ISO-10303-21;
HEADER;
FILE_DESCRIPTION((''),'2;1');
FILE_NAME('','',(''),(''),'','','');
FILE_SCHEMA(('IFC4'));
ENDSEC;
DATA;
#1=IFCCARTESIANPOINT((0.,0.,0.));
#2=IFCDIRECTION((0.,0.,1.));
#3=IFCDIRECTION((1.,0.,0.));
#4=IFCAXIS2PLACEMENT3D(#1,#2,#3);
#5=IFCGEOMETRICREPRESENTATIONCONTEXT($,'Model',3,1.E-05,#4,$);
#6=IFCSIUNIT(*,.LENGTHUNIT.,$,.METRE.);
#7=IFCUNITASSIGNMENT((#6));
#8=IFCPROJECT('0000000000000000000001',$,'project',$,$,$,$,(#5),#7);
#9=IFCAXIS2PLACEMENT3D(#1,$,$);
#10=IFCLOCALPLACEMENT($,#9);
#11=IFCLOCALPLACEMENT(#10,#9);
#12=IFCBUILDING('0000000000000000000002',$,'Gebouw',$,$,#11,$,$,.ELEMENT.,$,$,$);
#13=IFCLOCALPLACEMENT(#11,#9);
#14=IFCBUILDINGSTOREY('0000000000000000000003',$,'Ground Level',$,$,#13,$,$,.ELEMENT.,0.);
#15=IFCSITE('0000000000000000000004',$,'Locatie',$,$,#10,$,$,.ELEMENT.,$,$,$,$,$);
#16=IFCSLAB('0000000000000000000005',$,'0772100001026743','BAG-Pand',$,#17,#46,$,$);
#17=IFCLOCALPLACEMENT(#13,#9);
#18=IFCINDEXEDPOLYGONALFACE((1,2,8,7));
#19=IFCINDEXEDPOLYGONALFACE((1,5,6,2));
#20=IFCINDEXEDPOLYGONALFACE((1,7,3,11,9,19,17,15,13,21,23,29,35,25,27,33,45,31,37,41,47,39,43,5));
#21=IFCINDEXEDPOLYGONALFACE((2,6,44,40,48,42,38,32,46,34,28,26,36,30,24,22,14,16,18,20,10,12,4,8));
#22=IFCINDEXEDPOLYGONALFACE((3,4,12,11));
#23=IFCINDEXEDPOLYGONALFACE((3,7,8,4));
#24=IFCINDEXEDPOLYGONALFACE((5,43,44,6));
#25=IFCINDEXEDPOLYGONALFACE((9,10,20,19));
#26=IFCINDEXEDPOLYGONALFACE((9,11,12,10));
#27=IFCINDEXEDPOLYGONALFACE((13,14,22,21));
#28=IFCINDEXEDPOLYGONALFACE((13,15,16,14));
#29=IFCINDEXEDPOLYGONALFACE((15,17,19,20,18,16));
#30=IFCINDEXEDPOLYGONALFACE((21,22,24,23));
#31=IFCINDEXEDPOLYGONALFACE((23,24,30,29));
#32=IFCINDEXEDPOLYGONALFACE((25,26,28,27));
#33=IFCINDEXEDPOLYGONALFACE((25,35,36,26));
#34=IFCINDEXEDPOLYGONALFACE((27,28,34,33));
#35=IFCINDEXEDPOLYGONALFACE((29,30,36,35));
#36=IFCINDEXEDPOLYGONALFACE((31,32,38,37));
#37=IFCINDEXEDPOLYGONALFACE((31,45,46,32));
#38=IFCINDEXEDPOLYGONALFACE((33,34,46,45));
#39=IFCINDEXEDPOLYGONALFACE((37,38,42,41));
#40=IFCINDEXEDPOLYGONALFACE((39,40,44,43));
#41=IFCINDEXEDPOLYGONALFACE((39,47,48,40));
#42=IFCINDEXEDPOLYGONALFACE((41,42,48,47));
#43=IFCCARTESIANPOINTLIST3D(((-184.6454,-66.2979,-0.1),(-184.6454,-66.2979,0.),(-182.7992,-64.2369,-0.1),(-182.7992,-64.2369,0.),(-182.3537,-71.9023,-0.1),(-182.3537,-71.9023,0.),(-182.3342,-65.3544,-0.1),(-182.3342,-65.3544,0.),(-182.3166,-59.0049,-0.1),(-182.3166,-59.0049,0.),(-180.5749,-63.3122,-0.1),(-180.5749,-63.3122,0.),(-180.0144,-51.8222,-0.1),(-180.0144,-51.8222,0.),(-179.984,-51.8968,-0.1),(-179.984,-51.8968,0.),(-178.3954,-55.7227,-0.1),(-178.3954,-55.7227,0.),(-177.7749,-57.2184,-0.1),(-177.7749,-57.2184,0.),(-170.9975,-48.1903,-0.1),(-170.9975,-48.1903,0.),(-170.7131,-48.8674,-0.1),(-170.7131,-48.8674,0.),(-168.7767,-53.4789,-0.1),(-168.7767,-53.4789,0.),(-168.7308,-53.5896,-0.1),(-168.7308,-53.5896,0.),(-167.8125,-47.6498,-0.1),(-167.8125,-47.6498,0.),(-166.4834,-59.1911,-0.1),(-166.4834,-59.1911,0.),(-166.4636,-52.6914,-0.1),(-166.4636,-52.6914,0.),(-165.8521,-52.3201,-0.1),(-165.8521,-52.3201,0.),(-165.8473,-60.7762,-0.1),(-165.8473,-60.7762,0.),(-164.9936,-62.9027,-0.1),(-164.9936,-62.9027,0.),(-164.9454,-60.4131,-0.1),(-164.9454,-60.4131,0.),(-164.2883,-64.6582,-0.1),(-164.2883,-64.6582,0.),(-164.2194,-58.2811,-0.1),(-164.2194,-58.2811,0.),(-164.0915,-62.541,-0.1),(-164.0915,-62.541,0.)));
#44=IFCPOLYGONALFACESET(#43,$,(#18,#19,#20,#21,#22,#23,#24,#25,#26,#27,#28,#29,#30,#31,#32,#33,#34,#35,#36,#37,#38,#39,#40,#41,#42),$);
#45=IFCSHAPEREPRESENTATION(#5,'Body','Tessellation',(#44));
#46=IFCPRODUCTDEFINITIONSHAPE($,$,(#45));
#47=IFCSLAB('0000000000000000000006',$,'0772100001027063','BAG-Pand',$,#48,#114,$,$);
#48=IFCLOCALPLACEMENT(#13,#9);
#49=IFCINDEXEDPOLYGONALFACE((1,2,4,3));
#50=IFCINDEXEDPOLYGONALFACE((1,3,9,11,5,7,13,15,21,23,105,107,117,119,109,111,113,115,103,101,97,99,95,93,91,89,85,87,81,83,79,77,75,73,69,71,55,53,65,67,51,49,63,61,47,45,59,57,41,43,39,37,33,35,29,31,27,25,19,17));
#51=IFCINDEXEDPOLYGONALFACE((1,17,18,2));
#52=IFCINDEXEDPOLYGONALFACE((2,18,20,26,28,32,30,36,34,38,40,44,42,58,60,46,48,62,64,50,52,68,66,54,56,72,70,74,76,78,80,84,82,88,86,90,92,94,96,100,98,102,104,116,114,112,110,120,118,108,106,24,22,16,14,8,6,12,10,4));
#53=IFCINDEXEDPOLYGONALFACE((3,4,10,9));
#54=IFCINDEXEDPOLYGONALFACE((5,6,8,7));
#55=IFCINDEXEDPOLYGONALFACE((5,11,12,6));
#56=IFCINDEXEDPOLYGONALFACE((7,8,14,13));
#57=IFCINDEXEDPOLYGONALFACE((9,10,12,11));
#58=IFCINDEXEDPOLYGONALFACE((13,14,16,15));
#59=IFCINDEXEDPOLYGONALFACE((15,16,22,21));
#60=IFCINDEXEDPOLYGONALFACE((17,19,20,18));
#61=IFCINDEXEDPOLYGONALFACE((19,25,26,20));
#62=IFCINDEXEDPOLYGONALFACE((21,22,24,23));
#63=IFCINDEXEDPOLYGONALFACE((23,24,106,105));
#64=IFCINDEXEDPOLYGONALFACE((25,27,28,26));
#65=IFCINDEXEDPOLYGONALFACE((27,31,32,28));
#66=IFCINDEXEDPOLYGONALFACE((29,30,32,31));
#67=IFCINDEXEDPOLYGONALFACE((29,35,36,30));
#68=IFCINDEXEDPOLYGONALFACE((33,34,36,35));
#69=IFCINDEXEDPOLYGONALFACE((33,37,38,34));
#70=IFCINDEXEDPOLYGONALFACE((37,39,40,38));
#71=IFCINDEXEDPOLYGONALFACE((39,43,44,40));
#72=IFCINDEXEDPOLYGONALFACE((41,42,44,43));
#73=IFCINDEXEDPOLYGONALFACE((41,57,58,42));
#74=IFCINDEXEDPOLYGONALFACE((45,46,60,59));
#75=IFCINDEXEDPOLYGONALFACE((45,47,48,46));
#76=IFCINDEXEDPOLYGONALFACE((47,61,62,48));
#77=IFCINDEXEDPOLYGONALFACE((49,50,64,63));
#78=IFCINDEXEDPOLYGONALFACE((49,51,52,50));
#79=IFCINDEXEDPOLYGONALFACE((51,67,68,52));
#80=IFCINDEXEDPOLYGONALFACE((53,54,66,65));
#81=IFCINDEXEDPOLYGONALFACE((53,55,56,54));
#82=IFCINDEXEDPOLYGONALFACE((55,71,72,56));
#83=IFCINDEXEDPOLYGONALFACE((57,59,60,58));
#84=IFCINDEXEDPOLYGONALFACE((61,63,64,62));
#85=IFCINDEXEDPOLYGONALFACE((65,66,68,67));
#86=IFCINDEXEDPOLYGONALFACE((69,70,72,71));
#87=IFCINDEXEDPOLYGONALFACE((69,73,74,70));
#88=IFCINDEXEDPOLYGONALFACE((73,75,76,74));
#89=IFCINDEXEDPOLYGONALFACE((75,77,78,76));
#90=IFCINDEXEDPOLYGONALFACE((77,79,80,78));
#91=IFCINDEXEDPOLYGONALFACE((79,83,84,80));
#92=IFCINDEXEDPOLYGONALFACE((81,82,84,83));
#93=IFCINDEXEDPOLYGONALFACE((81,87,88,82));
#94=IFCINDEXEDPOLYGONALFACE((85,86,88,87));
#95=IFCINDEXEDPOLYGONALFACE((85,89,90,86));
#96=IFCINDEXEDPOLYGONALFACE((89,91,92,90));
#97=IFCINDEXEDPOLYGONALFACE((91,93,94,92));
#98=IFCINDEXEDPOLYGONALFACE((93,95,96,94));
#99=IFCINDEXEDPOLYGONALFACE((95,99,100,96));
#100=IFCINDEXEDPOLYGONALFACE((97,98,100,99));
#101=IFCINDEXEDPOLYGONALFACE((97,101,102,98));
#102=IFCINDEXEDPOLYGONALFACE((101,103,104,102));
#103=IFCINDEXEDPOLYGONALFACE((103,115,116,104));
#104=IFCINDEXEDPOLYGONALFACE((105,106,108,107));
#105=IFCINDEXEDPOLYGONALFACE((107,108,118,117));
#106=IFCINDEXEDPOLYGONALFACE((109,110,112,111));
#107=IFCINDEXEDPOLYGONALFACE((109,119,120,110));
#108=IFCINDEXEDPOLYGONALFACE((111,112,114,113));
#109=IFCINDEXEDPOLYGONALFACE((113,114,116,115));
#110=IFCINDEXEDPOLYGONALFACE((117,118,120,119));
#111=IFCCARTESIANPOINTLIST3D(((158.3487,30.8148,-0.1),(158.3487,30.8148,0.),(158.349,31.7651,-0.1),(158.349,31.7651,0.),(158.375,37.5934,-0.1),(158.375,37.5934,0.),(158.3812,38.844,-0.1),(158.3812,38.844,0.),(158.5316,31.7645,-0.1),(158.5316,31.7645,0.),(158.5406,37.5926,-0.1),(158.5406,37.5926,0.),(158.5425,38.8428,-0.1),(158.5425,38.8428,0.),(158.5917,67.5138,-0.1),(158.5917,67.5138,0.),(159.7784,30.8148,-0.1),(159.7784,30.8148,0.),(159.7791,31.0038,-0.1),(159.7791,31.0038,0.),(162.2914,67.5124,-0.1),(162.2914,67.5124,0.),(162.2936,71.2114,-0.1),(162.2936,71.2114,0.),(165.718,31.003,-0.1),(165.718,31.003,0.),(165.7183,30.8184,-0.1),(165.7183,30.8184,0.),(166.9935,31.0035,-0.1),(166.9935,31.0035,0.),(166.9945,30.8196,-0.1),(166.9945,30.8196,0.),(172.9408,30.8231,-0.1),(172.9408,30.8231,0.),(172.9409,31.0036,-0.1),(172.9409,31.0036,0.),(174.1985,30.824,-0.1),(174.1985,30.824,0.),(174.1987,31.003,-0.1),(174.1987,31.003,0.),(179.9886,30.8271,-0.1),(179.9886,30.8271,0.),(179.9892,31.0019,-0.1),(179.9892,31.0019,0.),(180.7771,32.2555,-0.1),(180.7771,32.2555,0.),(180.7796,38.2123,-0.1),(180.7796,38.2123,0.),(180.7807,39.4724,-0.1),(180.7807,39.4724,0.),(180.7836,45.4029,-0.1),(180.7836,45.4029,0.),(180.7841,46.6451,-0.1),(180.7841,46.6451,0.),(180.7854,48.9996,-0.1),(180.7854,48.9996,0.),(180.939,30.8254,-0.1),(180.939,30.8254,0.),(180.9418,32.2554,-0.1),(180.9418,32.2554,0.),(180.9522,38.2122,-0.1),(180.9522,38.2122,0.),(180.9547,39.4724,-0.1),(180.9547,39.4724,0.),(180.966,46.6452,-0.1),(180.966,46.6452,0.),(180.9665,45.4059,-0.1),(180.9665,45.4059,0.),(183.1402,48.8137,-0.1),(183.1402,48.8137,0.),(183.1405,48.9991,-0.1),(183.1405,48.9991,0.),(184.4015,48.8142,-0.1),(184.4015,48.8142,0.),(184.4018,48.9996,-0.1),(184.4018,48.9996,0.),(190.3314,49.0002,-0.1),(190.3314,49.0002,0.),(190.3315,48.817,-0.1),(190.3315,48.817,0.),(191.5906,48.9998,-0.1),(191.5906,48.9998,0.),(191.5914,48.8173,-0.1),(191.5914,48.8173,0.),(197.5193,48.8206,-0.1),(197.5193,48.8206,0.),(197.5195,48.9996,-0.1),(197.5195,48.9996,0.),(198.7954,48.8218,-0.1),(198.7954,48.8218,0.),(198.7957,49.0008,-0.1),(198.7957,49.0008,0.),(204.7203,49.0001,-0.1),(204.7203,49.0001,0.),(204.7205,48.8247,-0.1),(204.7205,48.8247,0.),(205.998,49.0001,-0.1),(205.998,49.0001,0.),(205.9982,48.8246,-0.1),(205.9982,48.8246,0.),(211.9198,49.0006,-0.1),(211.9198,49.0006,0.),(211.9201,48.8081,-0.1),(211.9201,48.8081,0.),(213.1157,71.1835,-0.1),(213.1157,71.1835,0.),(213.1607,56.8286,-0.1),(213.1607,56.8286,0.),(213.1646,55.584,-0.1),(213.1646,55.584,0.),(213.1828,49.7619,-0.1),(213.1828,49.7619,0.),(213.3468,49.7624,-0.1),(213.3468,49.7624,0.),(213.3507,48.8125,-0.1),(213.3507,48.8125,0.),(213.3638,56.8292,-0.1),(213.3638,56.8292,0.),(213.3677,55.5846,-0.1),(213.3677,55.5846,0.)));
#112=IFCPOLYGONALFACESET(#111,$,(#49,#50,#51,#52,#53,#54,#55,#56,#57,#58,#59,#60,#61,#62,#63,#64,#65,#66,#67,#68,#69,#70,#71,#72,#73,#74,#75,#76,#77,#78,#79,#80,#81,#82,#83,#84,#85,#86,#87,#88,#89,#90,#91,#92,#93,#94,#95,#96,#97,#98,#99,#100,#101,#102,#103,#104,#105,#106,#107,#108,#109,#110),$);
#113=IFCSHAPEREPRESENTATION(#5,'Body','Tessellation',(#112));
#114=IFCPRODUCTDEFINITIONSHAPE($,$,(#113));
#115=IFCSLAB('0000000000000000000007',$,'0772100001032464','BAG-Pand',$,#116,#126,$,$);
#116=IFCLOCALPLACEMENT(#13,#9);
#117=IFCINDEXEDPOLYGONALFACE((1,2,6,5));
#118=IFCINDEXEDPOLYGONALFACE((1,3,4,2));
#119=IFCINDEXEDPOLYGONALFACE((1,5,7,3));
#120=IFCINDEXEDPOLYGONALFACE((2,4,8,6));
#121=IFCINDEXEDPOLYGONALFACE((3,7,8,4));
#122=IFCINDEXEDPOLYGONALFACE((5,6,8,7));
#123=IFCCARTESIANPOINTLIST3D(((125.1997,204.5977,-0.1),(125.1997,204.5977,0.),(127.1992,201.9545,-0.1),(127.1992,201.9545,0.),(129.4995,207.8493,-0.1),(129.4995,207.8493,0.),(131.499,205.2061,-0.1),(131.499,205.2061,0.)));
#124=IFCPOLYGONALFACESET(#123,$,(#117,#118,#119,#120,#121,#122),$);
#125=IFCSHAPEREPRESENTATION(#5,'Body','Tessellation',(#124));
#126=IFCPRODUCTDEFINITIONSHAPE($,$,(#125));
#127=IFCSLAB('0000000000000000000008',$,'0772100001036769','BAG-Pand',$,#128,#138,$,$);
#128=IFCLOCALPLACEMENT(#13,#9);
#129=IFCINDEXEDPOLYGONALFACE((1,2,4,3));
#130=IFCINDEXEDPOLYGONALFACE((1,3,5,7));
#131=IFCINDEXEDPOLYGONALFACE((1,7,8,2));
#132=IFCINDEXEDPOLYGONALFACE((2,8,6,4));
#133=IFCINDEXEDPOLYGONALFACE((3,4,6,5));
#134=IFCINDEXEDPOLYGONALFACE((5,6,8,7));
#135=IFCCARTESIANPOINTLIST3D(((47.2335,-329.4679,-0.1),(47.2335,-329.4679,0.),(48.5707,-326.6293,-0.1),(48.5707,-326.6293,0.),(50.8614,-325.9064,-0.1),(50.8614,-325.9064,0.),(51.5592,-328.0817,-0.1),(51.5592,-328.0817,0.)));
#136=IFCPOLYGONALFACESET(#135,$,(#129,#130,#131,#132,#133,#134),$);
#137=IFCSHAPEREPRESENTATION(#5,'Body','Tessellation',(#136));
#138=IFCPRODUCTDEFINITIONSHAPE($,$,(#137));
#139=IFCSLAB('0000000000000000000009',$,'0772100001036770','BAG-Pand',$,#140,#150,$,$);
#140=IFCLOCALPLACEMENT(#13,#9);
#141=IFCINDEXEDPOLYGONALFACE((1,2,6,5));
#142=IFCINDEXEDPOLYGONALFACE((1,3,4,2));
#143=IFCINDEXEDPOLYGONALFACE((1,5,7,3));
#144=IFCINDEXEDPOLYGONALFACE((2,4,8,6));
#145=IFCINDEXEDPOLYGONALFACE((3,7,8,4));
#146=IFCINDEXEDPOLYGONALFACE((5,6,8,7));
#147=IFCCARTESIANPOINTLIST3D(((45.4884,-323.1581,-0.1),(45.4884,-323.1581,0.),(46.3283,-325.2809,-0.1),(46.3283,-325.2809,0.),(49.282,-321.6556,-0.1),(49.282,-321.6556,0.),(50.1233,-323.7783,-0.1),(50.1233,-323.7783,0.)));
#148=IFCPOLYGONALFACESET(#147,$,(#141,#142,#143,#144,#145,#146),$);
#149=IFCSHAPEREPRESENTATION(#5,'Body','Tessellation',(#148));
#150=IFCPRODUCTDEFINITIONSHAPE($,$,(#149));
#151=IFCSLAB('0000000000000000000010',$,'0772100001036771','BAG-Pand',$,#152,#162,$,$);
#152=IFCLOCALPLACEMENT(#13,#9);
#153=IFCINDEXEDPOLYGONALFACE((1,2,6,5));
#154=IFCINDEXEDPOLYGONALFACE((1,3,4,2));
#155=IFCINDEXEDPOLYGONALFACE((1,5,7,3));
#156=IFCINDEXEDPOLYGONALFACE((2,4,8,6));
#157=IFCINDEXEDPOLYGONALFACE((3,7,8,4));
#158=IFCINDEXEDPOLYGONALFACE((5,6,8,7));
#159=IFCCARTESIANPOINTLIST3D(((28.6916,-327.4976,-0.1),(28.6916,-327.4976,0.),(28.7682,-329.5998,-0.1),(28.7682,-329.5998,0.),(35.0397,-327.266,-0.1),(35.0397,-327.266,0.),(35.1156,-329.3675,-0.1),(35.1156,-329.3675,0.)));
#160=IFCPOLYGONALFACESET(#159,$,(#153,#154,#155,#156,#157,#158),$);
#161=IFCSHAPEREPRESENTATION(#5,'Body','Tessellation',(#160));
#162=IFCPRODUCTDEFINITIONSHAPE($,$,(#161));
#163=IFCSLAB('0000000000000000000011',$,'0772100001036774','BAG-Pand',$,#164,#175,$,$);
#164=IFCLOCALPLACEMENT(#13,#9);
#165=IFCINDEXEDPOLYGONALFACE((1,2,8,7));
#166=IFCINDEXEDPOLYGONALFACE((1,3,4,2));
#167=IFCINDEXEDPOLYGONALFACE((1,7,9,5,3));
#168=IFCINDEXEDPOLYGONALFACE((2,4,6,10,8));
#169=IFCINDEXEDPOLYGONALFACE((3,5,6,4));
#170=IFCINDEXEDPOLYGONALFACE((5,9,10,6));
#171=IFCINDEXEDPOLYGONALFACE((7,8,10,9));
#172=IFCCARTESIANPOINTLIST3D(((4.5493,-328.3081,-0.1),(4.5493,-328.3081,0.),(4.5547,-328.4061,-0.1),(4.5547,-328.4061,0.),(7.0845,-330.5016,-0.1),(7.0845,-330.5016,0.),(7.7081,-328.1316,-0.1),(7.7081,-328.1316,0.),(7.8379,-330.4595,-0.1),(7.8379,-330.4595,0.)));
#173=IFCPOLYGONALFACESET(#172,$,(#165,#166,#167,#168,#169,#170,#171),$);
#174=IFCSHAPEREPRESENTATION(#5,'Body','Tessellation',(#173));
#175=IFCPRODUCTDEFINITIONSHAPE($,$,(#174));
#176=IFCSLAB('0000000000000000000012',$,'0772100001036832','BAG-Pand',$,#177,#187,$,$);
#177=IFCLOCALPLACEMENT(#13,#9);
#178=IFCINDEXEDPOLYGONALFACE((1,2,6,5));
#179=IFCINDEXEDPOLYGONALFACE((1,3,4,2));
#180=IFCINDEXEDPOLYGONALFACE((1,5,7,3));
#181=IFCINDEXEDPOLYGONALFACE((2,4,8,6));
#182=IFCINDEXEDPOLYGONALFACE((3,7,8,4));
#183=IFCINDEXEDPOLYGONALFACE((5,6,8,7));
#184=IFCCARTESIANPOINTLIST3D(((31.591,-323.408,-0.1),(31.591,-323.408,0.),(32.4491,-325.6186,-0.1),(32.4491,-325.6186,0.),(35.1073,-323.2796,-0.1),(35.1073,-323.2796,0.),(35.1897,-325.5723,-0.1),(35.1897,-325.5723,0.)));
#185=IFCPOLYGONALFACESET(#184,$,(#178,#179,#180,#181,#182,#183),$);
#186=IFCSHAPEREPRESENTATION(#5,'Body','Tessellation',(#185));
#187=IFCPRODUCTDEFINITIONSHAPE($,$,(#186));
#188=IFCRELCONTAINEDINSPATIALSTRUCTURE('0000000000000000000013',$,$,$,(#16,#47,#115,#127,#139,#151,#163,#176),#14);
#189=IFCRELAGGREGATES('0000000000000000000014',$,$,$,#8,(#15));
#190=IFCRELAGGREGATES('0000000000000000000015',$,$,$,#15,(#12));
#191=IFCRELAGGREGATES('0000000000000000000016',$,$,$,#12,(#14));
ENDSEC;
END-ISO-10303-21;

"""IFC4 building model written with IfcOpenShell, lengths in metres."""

from ifc_helpers import new_model, si_unit, frame, origin, origin_with_axes, place, context, project, spatial, polyline, outline, extrude, element, save


model = new_model("IFC4")

# Units and contexts
model_context = context("Model", 3, precision=1e-05, world=origin_with_axes())
ifc_project = project(units=[si_unit("LENGTHUNIT", "METRE")], contexts=[model_context])

# Site, building, storey
site_placement = place(None, origin())
site = spatial("IfcSite", under=ifc_project, at=site_placement, Name="Locatie", CompositionType="ELEMENT")
building_placement = place(site_placement, origin())
building = spatial("IfcBuilding", under=site, at=building_placement, Name="Gebouw", CompositionType="ELEMENT")
storey_placement = place(building_placement, origin())
storey = spatial("IfcBuildingStorey", under=building, at=storey_placement, Name="Ground Level", CompositionType="ELEMENT", Elevation=0.0)

# Slabs
slab_1_placement = place(storey_placement, origin())
element("IfcSlab", 1, at=slab_1_placement, inside=storey, Name="0772100001026743", Description="BAG-Pand", context=model_context, shape_type="SweptSolid", body=[
    extrude(outline(polyline([(-179.984, -51.8968), (-180.0144, -51.8222), (-170.9975, -48.1903), (-170.7131, -48.8674), (-167.8125, -47.6498), (-165.8521, -52.3201), (-168.7767, -53.4789), (-168.7308, -53.5896), (-166.4636, -52.6914), (-164.2194, -58.2811), (-166.4834, -59.1911), (-165.8473, -60.7762), (-164.9454, -60.4131), (-164.0915, -62.541), (-164.9936, -62.9027), (-164.2883, -64.6582), (-182.3537, -71.9023), (-184.6454, -66.2979), (-182.3342, -65.3544), (-182.7992, -64.2369), (-180.5749, -63.3122), (-182.3166, -59.0049), (-177.7749, -57.2184), (-178.3954, -55.7227), (-179.984, -51.8968)])), frame((0.0, 0.0, -0.1), z_axis=(0.0, 0.0, 1.0), x_axis=(1.0, 0.0, 0.0)), (0.0, 0.0, 1.0), 0.1),
])
slab_2_placement = place(storey_placement, origin())
element("IfcSlab", 2, at=slab_2_placement, inside=storey, Name="0772100001027063", Description="BAG-Pand", context=model_context, shape_type="SweptSolid", body=[
    extrude(outline(polyline([(158.349, 31.7651), (158.5316, 31.7645), (158.5406, 37.5926), (158.375, 37.5934), (158.3812, 38.844), (158.5425, 38.8428), (158.5917, 67.5138), (162.2914, 67.5124), (162.2936, 71.2114), (213.1157, 71.1835), (213.1607, 56.8286), (213.3638, 56.8292), (213.3677, 55.5846), (213.1646, 55.584), (213.1828, 49.7619), (213.3468, 49.7624), (213.3507, 48.8125), (211.9201, 48.8081), (211.9198, 49.0006), (205.998, 49.0001), (205.9982, 48.8246), (204.7205, 48.8247), (204.7203, 49.0001), (198.7957, 49.0008), (198.7954, 48.8218), (197.5193, 48.8206), (197.5195, 48.9996), (191.5906, 48.9998), (191.5914, 48.8173), (190.3315, 48.817), (190.3314, 49.0002), (184.4018, 48.9996), (184.4015, 48.8142), (183.1402, 48.8137), (183.1405, 48.9991), (180.7854, 48.9996), (180.7841, 46.6451), (180.966, 46.6452), (180.9665, 45.4059), (180.7836, 45.4029), (180.7807, 39.4724), (180.9547, 39.4724), (180.9522, 38.2122), (180.7796, 38.2123), (180.7771, 32.2555), (180.9418, 32.2554), (180.939, 30.8254), (179.9886, 30.8271), (179.9892, 31.0019), (174.1987, 31.003), (174.1985, 30.824), (172.9408, 30.8231), (172.9409, 31.0036), (166.9935, 31.0035), (166.9945, 30.8196), (165.7183, 30.8184), (165.718, 31.003), (159.7791, 31.0038), (159.7784, 30.8148), (158.3487, 30.8148), (158.349, 31.7651)])), frame((0.0, 0.0, -0.1), z_axis=(0.0, 0.0, 1.0), x_axis=(1.0, 0.0, 0.0)), (0.0, 0.0, 1.0), 0.1),
])
slab_3_placement = place(storey_placement, origin())
element("IfcSlab", 3, at=slab_3_placement, inside=storey, Name="0772100001032464", Description="BAG-Pand", context=model_context, shape_type="SweptSolid", body=[
    extrude(outline(polyline([(125.1997, 204.5977), (129.4995, 207.8493), (131.499, 205.2061), (127.1992, 201.9545), (125.1997, 204.5977)])), frame((0.0, 0.0, -0.1), z_axis=(0.0, 0.0, 1.0), x_axis=(1.0, 0.0, 0.0)), (0.0, 0.0, 1.0), 0.1),
])
slab_4_placement = place(storey_placement, origin())
element("IfcSlab", 4, at=slab_4_placement, inside=storey, Name="0772100001036769", Description="BAG-Pand", context=model_context, shape_type="SweptSolid", body=[
    extrude(outline(polyline([(48.5707, -326.6293), (50.8614, -325.9064), (51.5592, -328.0817), (47.2335, -329.4679), (48.5707, -326.6293)])), frame((0.0, 0.0, -0.1), z_axis=(0.0, 0.0, 1.0), x_axis=(1.0, 0.0, 0.0)), (0.0, 0.0, 1.0), 0.1),
])
slab_5_placement = place(storey_placement, origin())
element("IfcSlab", 5, at=slab_5_placement, inside=storey, Name="0772100001036770", Description="BAG-Pand", context=model_context, shape_type="SweptSolid", body=[
    extrude(outline(polyline([(45.4884, -323.1581), (49.282, -321.6556), (50.1233, -323.7783), (46.3283, -325.2809), (45.4884, -323.1581)])), frame((0.0, 0.0, -0.1), z_axis=(0.0, 0.0, 1.0), x_axis=(1.0, 0.0, 0.0)), (0.0, 0.0, 1.0), 0.1),
])
slab_6_placement = place(storey_placement, origin())
element("IfcSlab", 6, at=slab_6_placement, inside=storey, Name="0772100001036771", Description="BAG-Pand", context=model_context, shape_type="SweptSolid", body=[
    extrude(outline(polyline([(28.6916, -327.4976), (35.0397, -327.266), (35.1156, -329.3675), (28.7682, -329.5998), (28.6916, -327.4976)])), frame((0.0, 0.0, -0.1), z_axis=(0.0, 0.0, 1.0), x_axis=(1.0, 0.0, 0.0)), (0.0, 0.0, 1.0), 0.1),
])
slab_7_placement = place(storey_placement, origin())
element("IfcSlab", 7, at=slab_7_placement, inside=storey, Name="0772100001036774", Description="BAG-Pand", context=model_context, shape_type="SweptSolid", body=[
    extrude(outline(polyline([(4.5493, -328.3081), (7.7081, -328.1316), (7.8379, -330.4595), (7.0845, -330.5016), (4.5547, -328.4061), (4.5493, -328.3081)])), frame((0.0, 0.0, -0.1), z_axis=(0.0, 0.0, 1.0), x_axis=(1.0, 0.0, 0.0)), (0.0, 0.0, 1.0), 0.1),
])
slab_8_placement = place(storey_placement, origin())
element("IfcSlab", 8, at=slab_8_placement, inside=storey, Name="0772100001036832", Description="BAG-Pand", context=model_context, shape_type="SweptSolid", body=[
    extrude(outline(polyline([(31.591, -323.408), (35.1073, -323.2796), (35.1897, -325.5723), (32.4491, -325.6186), (31.591, -323.408)])), frame((0.0, 0.0, -0.1), z_axis=(0.0, 0.0, 1.0), x_axis=(1.0, 0.0, 0.0)), (0.0, 0.0, 1.0), 0.1),
])

save(model, "model.ifc")
